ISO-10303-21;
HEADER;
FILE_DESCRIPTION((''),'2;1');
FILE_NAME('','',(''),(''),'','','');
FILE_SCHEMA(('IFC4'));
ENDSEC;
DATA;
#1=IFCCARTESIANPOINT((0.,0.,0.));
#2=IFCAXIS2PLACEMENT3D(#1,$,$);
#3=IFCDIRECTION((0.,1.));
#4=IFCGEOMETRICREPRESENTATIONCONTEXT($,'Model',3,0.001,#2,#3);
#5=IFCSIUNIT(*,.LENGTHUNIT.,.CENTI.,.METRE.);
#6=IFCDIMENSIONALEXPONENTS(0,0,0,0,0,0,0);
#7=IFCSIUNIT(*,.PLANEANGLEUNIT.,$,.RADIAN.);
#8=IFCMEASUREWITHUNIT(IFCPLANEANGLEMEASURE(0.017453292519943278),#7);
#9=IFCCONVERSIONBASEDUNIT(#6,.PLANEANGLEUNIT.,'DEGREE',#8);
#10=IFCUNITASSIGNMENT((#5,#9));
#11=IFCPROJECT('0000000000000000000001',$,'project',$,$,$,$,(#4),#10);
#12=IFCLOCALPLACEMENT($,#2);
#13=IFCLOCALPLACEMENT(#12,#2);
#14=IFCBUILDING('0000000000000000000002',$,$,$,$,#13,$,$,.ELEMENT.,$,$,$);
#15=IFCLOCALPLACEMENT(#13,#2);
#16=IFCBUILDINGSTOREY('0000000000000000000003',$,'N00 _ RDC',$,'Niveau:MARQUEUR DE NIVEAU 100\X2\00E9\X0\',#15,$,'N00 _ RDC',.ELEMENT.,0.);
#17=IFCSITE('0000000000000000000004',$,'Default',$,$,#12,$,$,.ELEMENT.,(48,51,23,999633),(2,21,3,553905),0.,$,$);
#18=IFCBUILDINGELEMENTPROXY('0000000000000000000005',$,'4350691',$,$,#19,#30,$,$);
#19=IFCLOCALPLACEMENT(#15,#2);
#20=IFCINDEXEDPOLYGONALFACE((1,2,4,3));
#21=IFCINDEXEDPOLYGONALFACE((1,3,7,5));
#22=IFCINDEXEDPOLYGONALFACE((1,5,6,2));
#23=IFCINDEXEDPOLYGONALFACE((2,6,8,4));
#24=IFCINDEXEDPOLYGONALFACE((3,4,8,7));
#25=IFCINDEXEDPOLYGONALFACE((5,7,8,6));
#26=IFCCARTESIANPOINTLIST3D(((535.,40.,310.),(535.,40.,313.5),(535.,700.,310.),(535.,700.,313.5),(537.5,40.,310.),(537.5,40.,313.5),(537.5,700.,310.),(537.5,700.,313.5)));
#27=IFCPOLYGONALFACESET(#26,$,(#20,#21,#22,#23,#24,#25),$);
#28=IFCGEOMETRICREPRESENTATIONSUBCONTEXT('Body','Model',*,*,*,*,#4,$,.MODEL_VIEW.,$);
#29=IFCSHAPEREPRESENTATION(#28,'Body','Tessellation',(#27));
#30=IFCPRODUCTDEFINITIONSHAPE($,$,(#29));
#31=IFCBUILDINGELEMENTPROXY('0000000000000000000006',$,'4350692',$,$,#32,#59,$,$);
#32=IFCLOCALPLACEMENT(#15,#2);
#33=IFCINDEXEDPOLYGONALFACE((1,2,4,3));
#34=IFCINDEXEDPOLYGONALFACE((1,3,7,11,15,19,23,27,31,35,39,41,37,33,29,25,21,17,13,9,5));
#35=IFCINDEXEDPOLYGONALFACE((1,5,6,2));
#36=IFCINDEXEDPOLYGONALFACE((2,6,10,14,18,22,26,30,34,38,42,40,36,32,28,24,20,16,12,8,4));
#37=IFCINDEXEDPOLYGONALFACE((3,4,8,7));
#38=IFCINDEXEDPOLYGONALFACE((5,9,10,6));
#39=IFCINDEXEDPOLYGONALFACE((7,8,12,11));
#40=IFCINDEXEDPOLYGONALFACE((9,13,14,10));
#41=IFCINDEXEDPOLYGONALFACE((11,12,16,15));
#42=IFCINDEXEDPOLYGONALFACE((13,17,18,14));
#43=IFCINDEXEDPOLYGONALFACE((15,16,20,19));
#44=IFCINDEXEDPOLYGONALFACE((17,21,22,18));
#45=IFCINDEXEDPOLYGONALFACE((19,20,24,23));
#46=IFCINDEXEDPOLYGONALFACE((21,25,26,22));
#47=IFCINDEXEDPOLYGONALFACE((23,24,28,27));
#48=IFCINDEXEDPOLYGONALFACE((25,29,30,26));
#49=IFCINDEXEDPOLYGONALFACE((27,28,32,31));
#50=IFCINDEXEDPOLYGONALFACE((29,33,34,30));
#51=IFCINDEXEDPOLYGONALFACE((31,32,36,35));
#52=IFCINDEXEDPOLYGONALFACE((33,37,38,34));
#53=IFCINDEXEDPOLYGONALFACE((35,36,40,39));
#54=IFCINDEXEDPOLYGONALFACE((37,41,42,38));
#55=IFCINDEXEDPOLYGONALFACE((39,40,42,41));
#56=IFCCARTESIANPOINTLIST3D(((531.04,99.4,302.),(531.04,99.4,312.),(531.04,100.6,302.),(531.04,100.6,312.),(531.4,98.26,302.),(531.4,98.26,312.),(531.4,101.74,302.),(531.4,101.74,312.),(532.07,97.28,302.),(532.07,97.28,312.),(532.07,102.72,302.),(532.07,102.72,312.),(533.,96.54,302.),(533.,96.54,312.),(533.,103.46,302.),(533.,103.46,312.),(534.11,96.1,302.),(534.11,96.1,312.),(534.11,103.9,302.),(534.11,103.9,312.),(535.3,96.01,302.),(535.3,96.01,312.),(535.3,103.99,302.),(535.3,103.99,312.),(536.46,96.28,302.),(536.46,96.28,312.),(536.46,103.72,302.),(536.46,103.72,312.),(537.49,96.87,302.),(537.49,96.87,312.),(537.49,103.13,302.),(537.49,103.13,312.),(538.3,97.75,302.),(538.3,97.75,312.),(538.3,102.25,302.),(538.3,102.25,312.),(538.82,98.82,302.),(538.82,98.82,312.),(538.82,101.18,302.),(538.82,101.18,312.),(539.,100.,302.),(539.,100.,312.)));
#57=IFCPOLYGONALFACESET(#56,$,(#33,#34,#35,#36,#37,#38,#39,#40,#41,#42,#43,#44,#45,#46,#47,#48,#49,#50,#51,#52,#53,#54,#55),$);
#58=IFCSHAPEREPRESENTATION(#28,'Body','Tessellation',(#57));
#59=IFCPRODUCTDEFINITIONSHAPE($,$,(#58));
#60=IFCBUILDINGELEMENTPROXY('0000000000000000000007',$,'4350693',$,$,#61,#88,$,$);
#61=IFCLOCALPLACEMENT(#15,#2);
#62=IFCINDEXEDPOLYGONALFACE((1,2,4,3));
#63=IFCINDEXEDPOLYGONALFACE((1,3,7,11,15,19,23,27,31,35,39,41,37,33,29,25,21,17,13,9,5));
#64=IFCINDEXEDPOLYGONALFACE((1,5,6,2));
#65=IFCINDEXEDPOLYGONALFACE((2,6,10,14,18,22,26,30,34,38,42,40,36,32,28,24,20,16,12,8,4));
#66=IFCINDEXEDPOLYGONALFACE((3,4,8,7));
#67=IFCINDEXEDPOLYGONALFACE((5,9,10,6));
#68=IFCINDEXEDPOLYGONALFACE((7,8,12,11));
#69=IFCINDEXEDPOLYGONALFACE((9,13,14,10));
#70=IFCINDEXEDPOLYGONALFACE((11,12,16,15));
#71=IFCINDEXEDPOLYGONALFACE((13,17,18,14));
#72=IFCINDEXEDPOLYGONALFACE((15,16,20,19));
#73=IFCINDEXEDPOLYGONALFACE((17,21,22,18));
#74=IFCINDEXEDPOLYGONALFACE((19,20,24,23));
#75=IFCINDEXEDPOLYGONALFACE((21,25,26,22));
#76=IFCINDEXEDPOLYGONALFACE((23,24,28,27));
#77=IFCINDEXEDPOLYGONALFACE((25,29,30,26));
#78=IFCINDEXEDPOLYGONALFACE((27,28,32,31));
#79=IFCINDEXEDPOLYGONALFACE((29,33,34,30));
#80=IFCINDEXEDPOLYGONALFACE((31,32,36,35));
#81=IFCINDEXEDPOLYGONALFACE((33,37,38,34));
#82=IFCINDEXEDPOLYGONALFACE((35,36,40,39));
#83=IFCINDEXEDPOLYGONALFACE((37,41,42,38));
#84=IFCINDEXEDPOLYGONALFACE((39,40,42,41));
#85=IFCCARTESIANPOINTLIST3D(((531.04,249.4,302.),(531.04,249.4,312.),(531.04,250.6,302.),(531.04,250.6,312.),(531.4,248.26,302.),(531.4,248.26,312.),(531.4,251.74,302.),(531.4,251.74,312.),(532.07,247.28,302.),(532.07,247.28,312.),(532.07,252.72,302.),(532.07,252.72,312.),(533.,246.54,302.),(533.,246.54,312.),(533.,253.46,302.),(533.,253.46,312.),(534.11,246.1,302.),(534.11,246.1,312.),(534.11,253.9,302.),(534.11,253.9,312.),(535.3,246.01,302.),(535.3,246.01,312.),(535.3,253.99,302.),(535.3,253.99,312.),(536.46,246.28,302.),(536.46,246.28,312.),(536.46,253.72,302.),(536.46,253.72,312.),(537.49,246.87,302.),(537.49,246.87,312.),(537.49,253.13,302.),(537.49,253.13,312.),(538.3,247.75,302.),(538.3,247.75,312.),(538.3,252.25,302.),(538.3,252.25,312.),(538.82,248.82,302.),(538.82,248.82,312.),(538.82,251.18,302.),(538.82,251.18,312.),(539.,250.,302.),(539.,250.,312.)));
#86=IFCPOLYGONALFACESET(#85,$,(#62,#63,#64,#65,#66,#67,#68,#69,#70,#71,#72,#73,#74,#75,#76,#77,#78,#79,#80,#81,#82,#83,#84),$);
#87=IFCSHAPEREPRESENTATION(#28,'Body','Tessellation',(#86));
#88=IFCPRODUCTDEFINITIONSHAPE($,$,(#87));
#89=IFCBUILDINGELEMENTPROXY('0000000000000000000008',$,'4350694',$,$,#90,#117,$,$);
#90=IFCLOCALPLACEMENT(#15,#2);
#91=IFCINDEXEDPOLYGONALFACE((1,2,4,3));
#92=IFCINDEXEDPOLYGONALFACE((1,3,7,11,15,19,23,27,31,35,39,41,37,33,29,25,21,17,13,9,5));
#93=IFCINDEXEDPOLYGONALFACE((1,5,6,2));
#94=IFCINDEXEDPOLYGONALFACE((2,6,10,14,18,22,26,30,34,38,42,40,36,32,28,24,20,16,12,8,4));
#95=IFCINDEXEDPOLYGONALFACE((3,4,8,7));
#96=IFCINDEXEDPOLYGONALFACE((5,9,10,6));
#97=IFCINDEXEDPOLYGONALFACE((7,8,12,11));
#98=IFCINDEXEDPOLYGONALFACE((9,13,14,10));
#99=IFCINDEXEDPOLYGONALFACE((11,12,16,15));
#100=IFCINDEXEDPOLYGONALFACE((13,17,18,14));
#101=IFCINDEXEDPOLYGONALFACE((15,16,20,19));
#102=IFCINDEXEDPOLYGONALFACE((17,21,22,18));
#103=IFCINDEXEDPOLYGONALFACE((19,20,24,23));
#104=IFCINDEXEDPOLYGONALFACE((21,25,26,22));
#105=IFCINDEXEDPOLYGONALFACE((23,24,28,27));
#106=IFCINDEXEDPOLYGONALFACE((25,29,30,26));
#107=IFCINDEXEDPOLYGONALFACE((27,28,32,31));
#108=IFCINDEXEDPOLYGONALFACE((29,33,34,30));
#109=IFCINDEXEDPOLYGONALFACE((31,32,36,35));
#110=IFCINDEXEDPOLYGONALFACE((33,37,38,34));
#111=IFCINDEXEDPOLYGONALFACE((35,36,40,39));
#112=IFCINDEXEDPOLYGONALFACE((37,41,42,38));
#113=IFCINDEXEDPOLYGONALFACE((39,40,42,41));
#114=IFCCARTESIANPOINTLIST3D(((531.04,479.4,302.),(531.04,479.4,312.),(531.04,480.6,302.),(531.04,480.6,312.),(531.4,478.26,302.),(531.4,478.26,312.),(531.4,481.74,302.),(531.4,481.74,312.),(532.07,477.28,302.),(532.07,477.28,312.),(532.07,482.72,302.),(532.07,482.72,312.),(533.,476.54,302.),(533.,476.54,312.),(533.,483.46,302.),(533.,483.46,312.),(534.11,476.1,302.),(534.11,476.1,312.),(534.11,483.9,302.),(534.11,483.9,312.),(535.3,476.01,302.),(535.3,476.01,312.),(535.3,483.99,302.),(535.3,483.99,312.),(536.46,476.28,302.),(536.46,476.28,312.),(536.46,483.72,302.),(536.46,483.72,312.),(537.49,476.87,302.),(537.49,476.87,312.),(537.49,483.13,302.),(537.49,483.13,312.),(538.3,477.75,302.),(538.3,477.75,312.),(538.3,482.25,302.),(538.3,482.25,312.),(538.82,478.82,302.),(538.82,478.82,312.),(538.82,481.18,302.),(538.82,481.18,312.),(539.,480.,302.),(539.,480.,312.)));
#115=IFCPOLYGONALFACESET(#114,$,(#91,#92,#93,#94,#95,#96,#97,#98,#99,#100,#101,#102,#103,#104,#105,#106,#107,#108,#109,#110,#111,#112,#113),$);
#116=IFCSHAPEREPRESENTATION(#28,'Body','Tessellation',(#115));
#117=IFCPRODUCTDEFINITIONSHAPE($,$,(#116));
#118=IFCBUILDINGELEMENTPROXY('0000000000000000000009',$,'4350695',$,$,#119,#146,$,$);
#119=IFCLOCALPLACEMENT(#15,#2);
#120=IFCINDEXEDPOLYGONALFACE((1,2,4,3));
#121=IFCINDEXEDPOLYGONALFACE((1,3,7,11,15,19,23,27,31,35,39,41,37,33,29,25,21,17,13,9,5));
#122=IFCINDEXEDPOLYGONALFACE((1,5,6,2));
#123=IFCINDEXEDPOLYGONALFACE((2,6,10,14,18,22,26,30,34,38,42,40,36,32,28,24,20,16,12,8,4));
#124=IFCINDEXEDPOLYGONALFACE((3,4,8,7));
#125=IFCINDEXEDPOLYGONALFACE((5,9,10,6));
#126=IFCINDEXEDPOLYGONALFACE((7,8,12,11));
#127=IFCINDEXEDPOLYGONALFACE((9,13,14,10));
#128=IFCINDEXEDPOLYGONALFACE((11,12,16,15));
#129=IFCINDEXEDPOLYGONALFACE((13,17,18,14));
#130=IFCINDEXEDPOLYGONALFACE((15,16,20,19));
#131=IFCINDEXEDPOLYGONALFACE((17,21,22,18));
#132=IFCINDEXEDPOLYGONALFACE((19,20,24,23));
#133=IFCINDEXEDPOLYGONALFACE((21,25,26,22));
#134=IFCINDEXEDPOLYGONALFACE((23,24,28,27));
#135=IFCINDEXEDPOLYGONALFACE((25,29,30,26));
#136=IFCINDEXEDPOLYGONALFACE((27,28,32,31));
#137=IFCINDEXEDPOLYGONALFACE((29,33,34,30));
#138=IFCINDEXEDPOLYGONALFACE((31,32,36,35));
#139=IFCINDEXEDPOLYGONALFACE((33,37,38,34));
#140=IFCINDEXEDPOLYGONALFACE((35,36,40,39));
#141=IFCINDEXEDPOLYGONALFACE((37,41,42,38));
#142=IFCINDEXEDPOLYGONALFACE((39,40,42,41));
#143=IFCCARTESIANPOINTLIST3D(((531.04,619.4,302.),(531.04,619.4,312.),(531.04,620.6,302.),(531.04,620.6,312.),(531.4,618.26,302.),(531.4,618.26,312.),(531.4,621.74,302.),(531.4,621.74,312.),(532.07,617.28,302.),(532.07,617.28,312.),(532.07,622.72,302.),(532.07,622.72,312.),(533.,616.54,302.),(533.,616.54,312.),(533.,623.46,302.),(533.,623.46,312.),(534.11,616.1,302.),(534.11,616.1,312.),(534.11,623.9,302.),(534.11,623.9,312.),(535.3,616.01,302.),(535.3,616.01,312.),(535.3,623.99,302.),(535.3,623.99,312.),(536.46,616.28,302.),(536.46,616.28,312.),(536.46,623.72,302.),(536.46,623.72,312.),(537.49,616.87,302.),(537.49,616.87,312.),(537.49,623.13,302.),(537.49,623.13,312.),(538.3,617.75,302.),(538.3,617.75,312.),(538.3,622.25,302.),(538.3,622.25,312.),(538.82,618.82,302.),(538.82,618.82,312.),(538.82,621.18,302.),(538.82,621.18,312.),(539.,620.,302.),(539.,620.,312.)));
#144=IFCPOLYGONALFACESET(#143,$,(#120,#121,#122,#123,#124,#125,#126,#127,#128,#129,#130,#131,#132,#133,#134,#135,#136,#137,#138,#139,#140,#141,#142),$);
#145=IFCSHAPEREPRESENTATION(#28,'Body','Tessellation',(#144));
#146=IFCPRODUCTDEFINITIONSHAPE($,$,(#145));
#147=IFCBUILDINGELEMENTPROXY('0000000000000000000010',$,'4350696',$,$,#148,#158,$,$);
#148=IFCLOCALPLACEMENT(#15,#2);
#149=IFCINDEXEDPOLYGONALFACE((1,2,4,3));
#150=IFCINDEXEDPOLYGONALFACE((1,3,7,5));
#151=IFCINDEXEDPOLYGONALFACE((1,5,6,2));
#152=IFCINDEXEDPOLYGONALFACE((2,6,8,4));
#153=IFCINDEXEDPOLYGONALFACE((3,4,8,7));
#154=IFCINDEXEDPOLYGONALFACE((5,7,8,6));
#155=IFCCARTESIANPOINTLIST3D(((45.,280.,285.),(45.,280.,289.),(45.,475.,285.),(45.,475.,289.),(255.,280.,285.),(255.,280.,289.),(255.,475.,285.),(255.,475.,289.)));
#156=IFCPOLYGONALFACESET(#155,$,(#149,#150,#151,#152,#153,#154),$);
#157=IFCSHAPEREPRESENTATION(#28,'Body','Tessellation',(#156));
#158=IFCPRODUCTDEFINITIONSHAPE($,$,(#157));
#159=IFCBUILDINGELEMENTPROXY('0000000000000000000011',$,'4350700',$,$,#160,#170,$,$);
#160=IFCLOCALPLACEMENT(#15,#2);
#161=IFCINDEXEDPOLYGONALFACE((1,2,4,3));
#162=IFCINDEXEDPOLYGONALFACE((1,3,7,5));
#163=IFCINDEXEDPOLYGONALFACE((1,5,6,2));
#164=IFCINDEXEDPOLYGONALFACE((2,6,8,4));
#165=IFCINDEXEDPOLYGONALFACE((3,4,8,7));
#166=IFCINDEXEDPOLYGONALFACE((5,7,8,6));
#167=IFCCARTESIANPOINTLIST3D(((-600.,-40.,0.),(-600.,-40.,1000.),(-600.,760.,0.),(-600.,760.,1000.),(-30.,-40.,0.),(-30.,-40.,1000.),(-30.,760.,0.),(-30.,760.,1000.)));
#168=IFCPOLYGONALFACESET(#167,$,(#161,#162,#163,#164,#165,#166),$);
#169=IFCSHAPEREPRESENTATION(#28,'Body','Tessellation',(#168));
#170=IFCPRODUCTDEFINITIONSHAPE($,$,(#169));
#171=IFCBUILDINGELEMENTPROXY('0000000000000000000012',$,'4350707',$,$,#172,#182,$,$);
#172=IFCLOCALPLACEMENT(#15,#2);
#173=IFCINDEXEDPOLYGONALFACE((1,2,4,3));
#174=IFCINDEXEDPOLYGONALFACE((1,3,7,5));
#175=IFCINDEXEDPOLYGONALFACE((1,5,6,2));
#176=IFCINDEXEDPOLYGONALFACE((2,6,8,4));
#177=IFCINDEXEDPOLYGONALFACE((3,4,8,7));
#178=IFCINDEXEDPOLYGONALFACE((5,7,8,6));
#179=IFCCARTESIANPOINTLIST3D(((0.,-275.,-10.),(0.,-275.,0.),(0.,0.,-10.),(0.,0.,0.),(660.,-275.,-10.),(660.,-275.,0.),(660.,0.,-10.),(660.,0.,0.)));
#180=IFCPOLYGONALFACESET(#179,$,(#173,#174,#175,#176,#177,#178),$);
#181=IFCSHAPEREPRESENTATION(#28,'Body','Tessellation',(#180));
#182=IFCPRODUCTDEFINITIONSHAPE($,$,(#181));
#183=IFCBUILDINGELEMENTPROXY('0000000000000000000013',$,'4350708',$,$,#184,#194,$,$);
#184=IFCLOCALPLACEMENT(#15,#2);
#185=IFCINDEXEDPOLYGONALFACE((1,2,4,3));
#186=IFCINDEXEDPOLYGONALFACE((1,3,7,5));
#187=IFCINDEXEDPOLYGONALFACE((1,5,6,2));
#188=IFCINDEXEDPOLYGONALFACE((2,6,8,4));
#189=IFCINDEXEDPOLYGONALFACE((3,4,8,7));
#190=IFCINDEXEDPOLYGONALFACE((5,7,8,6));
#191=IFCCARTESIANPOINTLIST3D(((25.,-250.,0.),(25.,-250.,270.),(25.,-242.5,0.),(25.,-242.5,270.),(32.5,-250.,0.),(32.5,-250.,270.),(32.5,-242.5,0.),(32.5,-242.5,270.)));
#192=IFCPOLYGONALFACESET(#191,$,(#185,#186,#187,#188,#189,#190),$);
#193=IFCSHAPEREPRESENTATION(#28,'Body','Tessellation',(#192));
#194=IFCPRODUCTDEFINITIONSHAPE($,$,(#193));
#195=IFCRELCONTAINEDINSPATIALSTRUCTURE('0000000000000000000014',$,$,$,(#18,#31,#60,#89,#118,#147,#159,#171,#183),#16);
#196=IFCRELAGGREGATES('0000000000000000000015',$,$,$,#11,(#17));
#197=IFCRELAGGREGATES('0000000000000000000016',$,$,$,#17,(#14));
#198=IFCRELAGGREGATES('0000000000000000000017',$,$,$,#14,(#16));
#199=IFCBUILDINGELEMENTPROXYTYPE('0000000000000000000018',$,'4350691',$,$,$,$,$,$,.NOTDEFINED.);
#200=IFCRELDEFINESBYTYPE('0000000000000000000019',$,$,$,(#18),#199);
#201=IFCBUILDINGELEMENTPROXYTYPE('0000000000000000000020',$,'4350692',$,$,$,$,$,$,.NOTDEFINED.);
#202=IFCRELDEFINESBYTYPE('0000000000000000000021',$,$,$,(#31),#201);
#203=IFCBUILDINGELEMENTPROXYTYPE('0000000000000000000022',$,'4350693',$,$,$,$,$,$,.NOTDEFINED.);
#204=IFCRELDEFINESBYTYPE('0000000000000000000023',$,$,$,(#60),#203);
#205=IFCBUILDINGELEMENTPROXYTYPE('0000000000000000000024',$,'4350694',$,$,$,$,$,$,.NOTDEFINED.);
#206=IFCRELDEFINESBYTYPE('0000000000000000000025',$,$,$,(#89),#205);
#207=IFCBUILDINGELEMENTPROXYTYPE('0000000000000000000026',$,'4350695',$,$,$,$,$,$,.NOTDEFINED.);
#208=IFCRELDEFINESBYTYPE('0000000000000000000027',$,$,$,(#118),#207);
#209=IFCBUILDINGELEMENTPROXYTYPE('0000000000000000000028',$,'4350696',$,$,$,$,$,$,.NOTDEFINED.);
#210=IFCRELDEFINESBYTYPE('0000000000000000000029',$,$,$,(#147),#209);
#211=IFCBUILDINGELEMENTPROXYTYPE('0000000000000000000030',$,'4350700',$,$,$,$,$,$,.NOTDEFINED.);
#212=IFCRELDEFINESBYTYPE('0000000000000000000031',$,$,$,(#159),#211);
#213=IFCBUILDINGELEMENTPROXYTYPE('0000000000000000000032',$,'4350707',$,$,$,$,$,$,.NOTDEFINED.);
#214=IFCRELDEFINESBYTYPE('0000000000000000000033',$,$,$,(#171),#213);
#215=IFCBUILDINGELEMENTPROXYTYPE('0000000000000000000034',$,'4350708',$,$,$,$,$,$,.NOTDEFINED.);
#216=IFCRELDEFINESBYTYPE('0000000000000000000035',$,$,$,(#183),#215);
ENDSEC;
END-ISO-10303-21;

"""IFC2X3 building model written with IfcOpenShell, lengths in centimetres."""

from ifc_helpers import new_model, entity, si_unit, converted_unit, direction, frame, frame_2d, origin, origin_2d_with_axis, place, context, subcontext, project, spatial, rectangle, circle, extrude, type_object, element, save


model = new_model("IFC2X3")

# Units and contexts
model_context = context("Model", 3, precision=0.001, world=origin(), true_north=direction((0.0, 1.0)))
body_context = subcontext(model_context, "Body", "Model", "MODEL_VIEW")
ifc_project = project(units=[si_unit("LENGTHUNIT", "METRE", prefix="CENTI"), converted_unit("PLANEANGLEUNIT", "DEGREE", entity("IfcPlaneAngleMeasure", 0.017453292519943278), si_unit("PLANEANGLEUNIT", "RADIAN"), dimensions=[0, 0, 0, 0, 0, 0, 0])], contexts=[model_context])

# Site, building, storey
site_placement = place(None, origin())
site = spatial("IfcSite", under=ifc_project, at=site_placement, Name="Default", CompositionType="ELEMENT", RefLatitude=(48, 51, 23, 999633), RefLongitude=(2, 21, 3, 553905), RefElevation=0.0)
building_placement = place(site_placement, origin())
building = spatial("IfcBuilding", under=site, at=building_placement, CompositionType="ELEMENT")
storey_placement = place(building_placement, origin())
storey = spatial("IfcBuildingStorey", under=building, at=storey_placement, Name="N00 _ RDC", ObjectType="Niveau:MARQUEUR DE NIVEAU 100é", LongName="N00 _ RDC", CompositionType="ELEMENT", Elevation=0.0)

# Building element proxies
building_element_proxy_type_1 = type_object("IfcBuildingElementProxyType", Name="4350691", PredefinedType="NOTDEFINED")
proxy_1_placement = place(storey_placement, origin())
element("IfcBuildingElementProxy", 1, at=proxy_1_placement, inside=storey, type_object=building_element_proxy_type_1, Name="4350691", context=body_context, shape_type="SweptSolid", body=[
    extrude(rectangle(XDim=2.5, YDim=660.0, at=frame_2d((0.0, 0.0), x_axis=(1.0, 0.0))), frame((536.25, 370.0, 310.0)), (0.0, 0.0, 1.0), 3.5),
])
building_element_proxy_type_2 = type_object("IfcBuildingElementProxyType", Name="4350692", PredefinedType="NOTDEFINED")
proxy_2_placement = place(storey_placement, origin())
element("IfcBuildingElementProxy", 2, at=proxy_2_placement, inside=storey, type_object=building_element_proxy_type_2, Name="4350692", context=body_context, shape_type="SweptSolid", body=[
    extrude(circle(Radius=4.0, at=origin_2d_with_axis()), frame((535.0, 100.0, 302.0)), (0.0, 0.0, 1.0), 10.0),
])
building_element_proxy_type_3 = type_object("IfcBuildingElementProxyType", Name="4350693", PredefinedType="NOTDEFINED")
proxy_3_placement = place(storey_placement, origin())
element("IfcBuildingElementProxy", 3, at=proxy_3_placement, inside=storey, type_object=building_element_proxy_type_3, Name="4350693", context=body_context, shape_type="SweptSolid", body=[
    extrude(circle(Radius=4.0, at=origin_2d_with_axis()), frame((535.0, 250.0, 302.0)), (0.0, 0.0, 1.0), 10.0),
])
building_element_proxy_type_4 = type_object("IfcBuildingElementProxyType", Name="4350694", PredefinedType="NOTDEFINED")
proxy_4_placement = place(storey_placement, origin())
element("IfcBuildingElementProxy", 4, at=proxy_4_placement, inside=storey, type_object=building_element_proxy_type_4, Name="4350694", context=body_context, shape_type="SweptSolid", body=[
    extrude(circle(Radius=4.0, at=origin_2d_with_axis()), frame((535.0, 480.0, 302.0)), (0.0, 0.0, 1.0), 10.0),
])
building_element_proxy_type_5 = type_object("IfcBuildingElementProxyType", Name="4350695", PredefinedType="NOTDEFINED")
proxy_5_placement = place(storey_placement, origin())
element("IfcBuildingElementProxy", 5, at=proxy_5_placement, inside=storey, type_object=building_element_proxy_type_5, Name="4350695", context=body_context, shape_type="SweptSolid", body=[
    extrude(circle(Radius=4.0, at=origin_2d_with_axis()), frame((535.0, 620.0, 302.0)), (0.0, 0.0, 1.0), 10.0),
])
building_element_proxy_type_6 = type_object("IfcBuildingElementProxyType", Name="4350696", PredefinedType="NOTDEFINED")
proxy_6_placement = place(storey_placement, origin())
element("IfcBuildingElementProxy", 6, at=proxy_6_placement, inside=storey, type_object=building_element_proxy_type_6, Name="4350696", context=body_context, shape_type="SweptSolid", body=[
    extrude(rectangle(XDim=210.0, YDim=195.0, at=frame_2d((0.0, 0.0), x_axis=(1.0, 0.0))), frame((150.0, 377.5, 285.0)), (0.0, 0.0, 1.0), 4.0),
])
building_element_proxy_type_7 = type_object("IfcBuildingElementProxyType", Name="4350700", PredefinedType="NOTDEFINED")
proxy_7_placement = place(storey_placement, origin())
element("IfcBuildingElementProxy", 7, at=proxy_7_placement, inside=storey, type_object=building_element_proxy_type_7, Name="4350700", context=body_context, shape_type="SweptSolid", body=[
    extrude(rectangle(XDim=570.0, YDim=800.0, at=origin_2d_with_axis()), frame((-315.0, 360.0, 0.0)), (0.0, 0.0, 1.0), 1000.0),
])
building_element_proxy_type_8 = type_object("IfcBuildingElementProxyType", Name="4350707", PredefinedType="NOTDEFINED")
proxy_8_placement = place(storey_placement, origin())
element("IfcBuildingElementProxy", 8, at=proxy_8_placement, inside=storey, type_object=building_element_proxy_type_8, Name="4350707", context=body_context, shape_type="SweptSolid", body=[
    extrude(rectangle(XDim=660.0, YDim=275.0, at=origin_2d_with_axis()), frame((330.0, -137.5, -10.0)), (0.0, 0.0, 1.0), 10.0),
])
building_element_proxy_type_9 = type_object("IfcBuildingElementProxyType", Name="4350708", PredefinedType="NOTDEFINED")
proxy_9_placement = place(storey_placement, origin())
element("IfcBuildingElementProxy", 9, at=proxy_9_placement, inside=storey, type_object=building_element_proxy_type_9, Name="4350708", context=body_context, shape_type="SweptSolid", body=[
    extrude(rectangle(XDim=7.5, YDim=7.5, at=frame_2d((0.0, 0.0), x_axis=(1.0, 0.0))), frame((28.75, -246.25, 0.0)), (0.0, 0.0, 1.0), 270.0),
])

save(model, "model.ifc")
